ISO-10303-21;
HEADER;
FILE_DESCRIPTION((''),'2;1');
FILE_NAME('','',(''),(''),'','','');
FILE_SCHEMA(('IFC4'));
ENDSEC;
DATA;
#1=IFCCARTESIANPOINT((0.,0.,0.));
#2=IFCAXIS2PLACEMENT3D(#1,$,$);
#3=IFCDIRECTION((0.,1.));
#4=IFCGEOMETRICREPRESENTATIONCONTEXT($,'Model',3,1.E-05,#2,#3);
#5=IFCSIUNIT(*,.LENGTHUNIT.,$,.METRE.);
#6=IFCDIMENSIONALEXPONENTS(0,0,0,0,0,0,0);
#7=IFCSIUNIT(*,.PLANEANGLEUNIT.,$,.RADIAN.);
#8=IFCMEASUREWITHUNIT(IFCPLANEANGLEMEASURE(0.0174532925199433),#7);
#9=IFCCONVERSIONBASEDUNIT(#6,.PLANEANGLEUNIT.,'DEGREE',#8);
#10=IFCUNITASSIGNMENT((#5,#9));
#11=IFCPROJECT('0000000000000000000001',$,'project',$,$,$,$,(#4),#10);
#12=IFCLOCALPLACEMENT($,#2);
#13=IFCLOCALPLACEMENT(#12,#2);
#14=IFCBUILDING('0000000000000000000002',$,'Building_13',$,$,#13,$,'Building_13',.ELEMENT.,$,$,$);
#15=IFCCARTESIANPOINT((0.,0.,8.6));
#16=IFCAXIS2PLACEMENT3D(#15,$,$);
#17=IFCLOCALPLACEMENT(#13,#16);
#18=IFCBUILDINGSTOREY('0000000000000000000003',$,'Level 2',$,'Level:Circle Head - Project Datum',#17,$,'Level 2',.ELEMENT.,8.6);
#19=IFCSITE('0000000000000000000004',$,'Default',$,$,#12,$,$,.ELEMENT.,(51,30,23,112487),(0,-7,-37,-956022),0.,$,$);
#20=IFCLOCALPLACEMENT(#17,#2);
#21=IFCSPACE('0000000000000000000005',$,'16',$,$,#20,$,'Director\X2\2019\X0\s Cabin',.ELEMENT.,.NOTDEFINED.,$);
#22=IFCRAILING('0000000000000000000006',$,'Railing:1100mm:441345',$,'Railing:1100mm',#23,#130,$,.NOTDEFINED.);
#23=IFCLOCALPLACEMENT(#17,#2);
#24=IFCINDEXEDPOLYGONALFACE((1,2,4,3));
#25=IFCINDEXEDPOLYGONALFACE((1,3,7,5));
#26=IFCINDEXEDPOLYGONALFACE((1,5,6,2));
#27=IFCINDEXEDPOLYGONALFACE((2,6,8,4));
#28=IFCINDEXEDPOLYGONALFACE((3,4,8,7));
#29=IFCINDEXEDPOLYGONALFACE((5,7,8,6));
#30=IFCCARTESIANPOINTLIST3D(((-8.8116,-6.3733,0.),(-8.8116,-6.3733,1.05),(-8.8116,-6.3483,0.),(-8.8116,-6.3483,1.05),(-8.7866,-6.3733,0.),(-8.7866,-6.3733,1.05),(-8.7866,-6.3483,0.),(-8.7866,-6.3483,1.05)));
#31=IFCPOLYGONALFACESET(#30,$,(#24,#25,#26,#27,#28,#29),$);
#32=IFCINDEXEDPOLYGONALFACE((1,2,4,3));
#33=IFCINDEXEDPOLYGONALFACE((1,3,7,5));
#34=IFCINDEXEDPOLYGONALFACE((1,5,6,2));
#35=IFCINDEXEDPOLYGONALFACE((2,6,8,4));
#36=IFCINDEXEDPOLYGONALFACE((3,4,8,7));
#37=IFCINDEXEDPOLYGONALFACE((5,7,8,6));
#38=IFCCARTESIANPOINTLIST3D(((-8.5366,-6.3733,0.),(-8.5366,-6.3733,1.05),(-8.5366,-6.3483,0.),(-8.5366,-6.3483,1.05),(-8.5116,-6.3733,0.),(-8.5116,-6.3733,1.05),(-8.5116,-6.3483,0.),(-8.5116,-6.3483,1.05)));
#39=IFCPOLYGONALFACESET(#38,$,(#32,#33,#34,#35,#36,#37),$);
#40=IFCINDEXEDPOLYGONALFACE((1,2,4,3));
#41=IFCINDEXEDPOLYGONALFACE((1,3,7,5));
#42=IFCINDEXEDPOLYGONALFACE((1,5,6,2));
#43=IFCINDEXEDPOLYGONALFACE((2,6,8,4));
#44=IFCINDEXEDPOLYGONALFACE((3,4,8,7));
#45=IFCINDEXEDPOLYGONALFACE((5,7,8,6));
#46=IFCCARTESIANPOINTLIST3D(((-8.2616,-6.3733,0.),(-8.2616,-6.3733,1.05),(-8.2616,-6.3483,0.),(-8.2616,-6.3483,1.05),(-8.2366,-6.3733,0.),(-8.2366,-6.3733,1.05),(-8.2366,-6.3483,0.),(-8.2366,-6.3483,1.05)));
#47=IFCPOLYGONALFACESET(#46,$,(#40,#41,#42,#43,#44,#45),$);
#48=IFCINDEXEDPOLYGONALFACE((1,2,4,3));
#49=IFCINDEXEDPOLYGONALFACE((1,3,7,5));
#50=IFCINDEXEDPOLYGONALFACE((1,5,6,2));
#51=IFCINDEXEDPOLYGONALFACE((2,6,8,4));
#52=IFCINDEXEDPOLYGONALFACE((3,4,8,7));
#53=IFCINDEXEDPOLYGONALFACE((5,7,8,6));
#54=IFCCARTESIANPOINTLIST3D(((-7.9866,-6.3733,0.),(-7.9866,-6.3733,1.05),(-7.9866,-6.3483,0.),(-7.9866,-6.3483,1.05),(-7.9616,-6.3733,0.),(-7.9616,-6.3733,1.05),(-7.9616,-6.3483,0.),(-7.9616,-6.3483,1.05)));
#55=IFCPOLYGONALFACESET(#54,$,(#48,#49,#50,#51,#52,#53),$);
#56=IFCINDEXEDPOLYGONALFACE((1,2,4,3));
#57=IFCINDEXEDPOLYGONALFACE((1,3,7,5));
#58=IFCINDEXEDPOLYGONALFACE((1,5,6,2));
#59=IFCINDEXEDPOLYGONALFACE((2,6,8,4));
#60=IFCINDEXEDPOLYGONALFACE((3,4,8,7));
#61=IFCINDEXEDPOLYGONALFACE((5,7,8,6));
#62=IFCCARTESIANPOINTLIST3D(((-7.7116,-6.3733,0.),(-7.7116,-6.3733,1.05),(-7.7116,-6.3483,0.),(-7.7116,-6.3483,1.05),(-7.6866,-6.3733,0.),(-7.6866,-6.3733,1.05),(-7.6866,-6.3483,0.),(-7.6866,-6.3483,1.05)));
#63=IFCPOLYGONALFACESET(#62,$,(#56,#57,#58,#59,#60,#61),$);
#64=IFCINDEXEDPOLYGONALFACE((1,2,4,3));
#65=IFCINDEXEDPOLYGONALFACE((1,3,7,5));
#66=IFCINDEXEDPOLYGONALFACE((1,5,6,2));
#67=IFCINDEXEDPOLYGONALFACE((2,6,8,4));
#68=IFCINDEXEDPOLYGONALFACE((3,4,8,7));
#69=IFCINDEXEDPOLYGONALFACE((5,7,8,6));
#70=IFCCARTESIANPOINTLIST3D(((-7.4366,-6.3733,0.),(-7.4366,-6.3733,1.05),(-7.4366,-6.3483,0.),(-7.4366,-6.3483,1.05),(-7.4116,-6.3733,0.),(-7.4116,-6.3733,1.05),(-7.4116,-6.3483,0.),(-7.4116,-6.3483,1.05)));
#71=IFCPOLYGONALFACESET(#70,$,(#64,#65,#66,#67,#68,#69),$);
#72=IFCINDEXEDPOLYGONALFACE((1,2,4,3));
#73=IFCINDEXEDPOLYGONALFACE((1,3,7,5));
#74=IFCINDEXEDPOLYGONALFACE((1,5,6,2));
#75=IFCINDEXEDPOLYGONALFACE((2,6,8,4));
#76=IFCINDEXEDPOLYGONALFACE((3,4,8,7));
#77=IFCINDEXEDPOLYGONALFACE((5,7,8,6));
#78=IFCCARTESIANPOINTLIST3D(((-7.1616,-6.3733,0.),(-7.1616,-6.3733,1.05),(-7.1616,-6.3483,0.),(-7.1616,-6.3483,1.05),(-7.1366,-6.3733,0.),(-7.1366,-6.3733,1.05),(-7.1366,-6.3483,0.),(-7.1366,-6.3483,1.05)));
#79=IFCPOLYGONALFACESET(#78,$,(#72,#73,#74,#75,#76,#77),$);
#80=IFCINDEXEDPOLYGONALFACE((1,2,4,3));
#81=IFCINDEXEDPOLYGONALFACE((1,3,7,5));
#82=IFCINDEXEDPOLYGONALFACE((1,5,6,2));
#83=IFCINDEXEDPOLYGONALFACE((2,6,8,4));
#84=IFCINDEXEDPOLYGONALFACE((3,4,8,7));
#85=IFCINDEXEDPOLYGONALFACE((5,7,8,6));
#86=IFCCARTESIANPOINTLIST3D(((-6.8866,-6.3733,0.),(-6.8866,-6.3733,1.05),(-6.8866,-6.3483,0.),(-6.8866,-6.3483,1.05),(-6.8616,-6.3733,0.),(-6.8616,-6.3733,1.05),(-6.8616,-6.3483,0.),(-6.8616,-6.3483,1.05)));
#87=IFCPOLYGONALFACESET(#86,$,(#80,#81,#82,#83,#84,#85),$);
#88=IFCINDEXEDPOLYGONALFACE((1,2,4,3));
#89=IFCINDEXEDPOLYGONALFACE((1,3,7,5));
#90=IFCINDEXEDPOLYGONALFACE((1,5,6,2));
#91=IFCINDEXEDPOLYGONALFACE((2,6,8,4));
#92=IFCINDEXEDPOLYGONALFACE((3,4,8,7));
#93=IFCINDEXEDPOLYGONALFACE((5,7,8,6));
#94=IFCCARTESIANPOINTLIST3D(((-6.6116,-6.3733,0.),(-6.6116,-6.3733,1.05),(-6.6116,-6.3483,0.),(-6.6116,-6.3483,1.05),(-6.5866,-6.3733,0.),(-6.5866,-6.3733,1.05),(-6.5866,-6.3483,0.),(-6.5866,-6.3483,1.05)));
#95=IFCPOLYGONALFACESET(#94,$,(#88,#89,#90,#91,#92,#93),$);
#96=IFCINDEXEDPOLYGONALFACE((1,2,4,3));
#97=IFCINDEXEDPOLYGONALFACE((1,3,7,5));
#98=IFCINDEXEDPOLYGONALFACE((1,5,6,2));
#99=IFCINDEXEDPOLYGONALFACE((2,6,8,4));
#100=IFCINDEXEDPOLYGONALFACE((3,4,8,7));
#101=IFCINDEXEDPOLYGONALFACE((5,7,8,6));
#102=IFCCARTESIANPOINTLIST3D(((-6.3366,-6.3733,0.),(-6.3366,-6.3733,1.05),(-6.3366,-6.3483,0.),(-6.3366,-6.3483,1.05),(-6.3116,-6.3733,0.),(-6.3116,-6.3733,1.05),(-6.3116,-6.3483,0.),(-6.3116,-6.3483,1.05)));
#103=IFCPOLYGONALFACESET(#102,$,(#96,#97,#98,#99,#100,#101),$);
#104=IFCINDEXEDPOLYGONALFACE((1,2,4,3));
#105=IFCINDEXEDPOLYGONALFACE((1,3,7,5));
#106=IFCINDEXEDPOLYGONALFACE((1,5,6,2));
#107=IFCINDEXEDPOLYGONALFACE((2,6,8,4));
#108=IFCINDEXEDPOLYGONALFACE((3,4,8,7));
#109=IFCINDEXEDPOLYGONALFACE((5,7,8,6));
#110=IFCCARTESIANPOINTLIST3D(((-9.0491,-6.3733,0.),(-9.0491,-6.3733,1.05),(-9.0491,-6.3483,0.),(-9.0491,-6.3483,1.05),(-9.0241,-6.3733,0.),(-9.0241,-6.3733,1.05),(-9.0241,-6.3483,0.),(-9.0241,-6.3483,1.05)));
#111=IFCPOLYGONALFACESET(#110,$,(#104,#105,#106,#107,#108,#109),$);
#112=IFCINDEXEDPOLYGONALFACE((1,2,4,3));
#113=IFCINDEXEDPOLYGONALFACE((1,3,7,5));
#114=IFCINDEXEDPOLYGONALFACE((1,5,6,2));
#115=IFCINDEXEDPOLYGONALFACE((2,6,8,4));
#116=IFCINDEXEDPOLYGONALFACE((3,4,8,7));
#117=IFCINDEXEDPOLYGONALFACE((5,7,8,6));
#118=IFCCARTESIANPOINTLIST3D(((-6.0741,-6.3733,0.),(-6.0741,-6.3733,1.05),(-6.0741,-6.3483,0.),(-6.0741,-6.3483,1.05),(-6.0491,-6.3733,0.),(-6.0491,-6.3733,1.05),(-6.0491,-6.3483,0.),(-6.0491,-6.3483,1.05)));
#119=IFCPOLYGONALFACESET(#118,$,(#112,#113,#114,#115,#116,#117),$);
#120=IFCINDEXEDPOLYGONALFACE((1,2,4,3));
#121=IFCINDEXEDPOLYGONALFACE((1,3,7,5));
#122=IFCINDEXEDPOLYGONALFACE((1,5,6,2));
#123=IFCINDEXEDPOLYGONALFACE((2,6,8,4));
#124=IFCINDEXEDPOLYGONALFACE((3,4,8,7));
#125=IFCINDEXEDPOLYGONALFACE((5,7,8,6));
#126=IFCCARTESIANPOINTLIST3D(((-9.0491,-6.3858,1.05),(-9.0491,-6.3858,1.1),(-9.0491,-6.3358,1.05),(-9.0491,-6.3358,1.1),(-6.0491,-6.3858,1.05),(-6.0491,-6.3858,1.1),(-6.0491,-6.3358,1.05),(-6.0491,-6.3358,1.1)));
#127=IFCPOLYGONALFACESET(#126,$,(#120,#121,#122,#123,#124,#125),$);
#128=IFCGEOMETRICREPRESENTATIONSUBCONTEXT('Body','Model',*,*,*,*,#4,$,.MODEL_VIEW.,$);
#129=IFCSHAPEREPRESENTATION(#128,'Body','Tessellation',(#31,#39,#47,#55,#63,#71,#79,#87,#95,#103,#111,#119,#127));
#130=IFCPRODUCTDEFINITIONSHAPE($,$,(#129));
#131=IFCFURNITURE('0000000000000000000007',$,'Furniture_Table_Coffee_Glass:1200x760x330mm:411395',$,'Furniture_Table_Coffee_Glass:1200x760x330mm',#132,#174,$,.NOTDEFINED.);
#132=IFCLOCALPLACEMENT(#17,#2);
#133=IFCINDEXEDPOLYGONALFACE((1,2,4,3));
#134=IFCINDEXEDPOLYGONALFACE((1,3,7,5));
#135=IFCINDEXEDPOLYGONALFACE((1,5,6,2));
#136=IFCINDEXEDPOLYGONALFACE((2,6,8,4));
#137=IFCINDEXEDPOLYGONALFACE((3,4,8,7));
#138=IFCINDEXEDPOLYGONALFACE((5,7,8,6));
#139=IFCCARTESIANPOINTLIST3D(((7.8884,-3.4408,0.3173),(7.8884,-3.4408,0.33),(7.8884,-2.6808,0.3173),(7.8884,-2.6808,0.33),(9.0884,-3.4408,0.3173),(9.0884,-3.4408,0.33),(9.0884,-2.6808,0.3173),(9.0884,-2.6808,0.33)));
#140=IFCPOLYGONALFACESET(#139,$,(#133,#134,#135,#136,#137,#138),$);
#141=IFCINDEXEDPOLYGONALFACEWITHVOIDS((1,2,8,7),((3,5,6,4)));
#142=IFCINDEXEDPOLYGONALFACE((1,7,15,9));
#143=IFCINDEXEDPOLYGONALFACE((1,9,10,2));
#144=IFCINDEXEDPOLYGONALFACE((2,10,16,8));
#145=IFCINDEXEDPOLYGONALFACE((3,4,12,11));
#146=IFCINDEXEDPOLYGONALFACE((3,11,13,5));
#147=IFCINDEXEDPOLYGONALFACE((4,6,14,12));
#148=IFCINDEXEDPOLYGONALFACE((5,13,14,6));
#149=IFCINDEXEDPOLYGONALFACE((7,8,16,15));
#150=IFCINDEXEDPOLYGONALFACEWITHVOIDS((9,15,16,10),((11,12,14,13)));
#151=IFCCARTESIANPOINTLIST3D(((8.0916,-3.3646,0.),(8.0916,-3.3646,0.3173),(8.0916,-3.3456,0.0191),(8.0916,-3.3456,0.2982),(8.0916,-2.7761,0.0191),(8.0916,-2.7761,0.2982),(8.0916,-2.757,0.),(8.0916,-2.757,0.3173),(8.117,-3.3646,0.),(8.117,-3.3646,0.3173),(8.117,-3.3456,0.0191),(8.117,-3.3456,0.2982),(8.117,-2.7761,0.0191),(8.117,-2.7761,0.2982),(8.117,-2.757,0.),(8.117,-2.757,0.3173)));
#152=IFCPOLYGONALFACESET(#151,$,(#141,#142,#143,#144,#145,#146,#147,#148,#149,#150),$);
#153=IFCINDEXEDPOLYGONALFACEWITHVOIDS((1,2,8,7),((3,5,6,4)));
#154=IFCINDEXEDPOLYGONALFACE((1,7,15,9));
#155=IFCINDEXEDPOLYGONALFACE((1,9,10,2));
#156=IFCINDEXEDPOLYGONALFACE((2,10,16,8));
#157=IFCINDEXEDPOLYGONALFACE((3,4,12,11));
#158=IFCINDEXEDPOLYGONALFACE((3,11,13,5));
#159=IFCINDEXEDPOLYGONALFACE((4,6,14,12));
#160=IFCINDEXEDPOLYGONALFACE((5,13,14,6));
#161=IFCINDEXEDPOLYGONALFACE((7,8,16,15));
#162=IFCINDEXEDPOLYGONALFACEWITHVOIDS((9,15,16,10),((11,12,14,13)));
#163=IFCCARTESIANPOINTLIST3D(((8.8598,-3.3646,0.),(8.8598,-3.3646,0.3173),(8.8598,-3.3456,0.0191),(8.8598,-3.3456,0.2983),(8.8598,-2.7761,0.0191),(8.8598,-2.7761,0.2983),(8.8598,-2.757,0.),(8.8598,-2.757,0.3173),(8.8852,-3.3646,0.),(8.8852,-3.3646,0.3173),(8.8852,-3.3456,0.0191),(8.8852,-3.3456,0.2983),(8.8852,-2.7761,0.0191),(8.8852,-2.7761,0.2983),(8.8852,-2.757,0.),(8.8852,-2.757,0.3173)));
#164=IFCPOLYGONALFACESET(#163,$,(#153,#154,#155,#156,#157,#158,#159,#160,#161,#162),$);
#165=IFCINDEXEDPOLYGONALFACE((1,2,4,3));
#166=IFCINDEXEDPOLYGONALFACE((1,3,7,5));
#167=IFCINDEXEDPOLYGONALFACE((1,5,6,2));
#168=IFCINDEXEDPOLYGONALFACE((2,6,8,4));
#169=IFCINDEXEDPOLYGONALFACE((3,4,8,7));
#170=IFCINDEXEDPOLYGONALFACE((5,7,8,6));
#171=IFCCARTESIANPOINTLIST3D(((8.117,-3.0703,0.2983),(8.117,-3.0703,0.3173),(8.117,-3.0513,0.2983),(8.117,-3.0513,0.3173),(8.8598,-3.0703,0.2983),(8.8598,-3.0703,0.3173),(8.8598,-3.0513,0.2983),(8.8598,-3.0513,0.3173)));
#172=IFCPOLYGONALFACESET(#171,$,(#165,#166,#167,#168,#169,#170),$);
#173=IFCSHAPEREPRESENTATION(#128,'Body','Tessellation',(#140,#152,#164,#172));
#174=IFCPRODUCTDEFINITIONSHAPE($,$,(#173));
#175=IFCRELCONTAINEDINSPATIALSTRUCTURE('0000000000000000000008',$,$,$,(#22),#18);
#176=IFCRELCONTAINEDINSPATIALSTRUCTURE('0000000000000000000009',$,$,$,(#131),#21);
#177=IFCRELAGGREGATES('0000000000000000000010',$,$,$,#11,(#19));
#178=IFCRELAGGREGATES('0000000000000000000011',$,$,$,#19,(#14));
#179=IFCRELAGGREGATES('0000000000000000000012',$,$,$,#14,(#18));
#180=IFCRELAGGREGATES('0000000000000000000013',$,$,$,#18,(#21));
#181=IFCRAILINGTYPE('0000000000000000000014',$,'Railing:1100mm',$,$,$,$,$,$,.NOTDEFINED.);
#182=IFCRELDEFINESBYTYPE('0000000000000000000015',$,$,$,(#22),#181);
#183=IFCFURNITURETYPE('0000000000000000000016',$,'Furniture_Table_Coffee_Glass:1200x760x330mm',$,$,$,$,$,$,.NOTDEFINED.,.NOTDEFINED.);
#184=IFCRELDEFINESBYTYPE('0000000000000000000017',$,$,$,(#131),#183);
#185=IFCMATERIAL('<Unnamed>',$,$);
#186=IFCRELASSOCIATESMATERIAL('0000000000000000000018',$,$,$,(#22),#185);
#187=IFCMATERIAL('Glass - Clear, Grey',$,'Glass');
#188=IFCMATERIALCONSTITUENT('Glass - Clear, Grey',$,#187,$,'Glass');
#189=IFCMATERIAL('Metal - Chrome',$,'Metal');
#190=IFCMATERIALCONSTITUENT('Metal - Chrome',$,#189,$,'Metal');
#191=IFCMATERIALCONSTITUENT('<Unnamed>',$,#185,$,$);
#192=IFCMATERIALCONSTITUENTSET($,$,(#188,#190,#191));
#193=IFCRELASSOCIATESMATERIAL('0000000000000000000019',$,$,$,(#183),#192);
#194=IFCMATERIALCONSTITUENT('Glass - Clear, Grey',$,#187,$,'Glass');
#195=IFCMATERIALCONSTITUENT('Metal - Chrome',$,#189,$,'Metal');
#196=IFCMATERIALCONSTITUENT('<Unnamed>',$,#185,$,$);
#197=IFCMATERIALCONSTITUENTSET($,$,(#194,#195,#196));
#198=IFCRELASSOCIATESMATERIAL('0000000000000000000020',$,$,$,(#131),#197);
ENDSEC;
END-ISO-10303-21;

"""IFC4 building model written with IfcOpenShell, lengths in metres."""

from ifc_helpers import new_model, entity, si_unit, converted_unit, direction, frame, origin, place, context, subcontext, project, spatial, indexed_curve, outline, extrude, source, transform, mapped, material, constituent, constituent_set, type_object, type_shapes, element, save


model = new_model("IFC4")

# Units and contexts
model_context = context("Model", 3, precision=1e-05, world=origin(), true_north=direction((0.0, 1.0)))
body_context = subcontext(model_context, "Body", "Model", "MODEL_VIEW")
ifc_project = project(units=[si_unit("LENGTHUNIT", "METRE"), converted_unit("PLANEANGLEUNIT", "DEGREE", entity("IfcPlaneAngleMeasure", 0.0174532925199433), si_unit("PLANEANGLEUNIT", "RADIAN"), dimensions=[0, 0, 0, 0, 0, 0, 0])], contexts=[model_context])

# Site, building, storey
site_placement = place(None, origin())
site = spatial("IfcSite", under=ifc_project, at=site_placement, Name="Default", CompositionType="ELEMENT", RefLatitude=(51, 30, 23, 112487), RefLongitude=(0, -7, -37, -956022), RefElevation=0.0)
building_placement = place(site_placement, origin())
building = spatial("IfcBuilding", under=site, at=building_placement, Name="Building_13", LongName="Building_13", CompositionType="ELEMENT")
storey_placement = place(building_placement, frame((0.0, 0.0, 8.6)))
storey = spatial("IfcBuildingStorey", under=building, at=storey_placement, Name="Level 2", ObjectType="Level:Circle Head - Project Datum", LongName="Level 2", CompositionType="ELEMENT", Elevation=8.6)

# Shared definitions
ifc_material_1 = material(Name="<Unnamed>")

# Shared definitions
railing_type_1 = type_object("IfcRailingType", Name="Railing:1100mm", PredefinedType="NOTDEFINED")

# Railing
railing_1_placement = place(storey_placement, origin())
element("IfcRailing", 1, at=railing_1_placement, inside=storey, type_object=railing_type_1, material=ifc_material_1, Name="Railing:1100mm:441345", ObjectType="Railing:1100mm", PredefinedType="NOTDEFINED", context=body_context, shape_type="SweptSolid", body=[
    extrude(outline(indexed_curve([(-0.0125, -0.0125), (0.0125, -0.0125), (0.0125, 0.0125), (-0.0125, 0.0125), (-0.0125, -0.0125)], self_intersect=False)), frame((-8.7991, -6.3608, 0.0), z_axis=(0.0, 0.0, 1.0), x_axis=(-1.0, 0.0, 0.0)), (0.0, 0.0, 1.0), 1.05),
    extrude(outline(indexed_curve([(-0.0125, -0.0125), (0.0125, -0.0125), (0.0125, 0.0125), (-0.0125, 0.0125), (-0.0125, -0.0125)], self_intersect=False)), frame((-8.5241, -6.3608, 0.0), z_axis=(0.0, 0.0, 1.0), x_axis=(-1.0, 0.0, 0.0)), (0.0, 0.0, 1.0), 1.05),
    extrude(outline(indexed_curve([(-0.0125, -0.0125), (0.0125, -0.0125), (0.0125, 0.0125), (-0.0125, 0.0125), (-0.0125, -0.0125)], self_intersect=False)), frame((-8.2491, -6.3608, 0.0), z_axis=(0.0, 0.0, 1.0), x_axis=(-1.0, 0.0, 0.0)), (0.0, 0.0, 1.0), 1.05),
    extrude(outline(indexed_curve([(-0.0125, -0.0125), (0.0125, -0.0125), (0.0125, 0.0125), (-0.0125, 0.0125), (-0.0125, -0.0125)], self_intersect=False)), frame((-7.9741, -6.3608, 0.0), z_axis=(0.0, 0.0, 1.0), x_axis=(-1.0, 0.0, 0.0)), (0.0, 0.0, 1.0), 1.05),
    extrude(outline(indexed_curve([(-0.0125, -0.0125), (0.0125, -0.0125), (0.0125, 0.0125), (-0.0125, 0.0125), (-0.0125, -0.0125)], self_intersect=False)), frame((-7.6991, -6.3608, 0.0), z_axis=(0.0, 0.0, 1.0), x_axis=(-1.0, 0.0, 0.0)), (0.0, 0.0, 1.0), 1.05),
    extrude(outline(indexed_curve([(-0.0125, -0.0125), (0.0125, -0.0125), (0.0125, 0.0125), (-0.0125, 0.0125), (-0.0125, -0.0125)], self_intersect=False)), frame((-7.4241, -6.3608, 0.0), z_axis=(0.0, 0.0, 1.0), x_axis=(-1.0, 0.0, 0.0)), (0.0, 0.0, 1.0), 1.05),
    extrude(outline(indexed_curve([(-0.0125, -0.0125), (0.0125, -0.0125), (0.0125, 0.0125), (-0.0125, 0.0125), (-0.0125, -0.0125)], self_intersect=False)), frame((-7.1491, -6.3608, 0.0), z_axis=(0.0, 0.0, 1.0), x_axis=(-1.0, 0.0, 0.0)), (0.0, 0.0, 1.0), 1.05),
    extrude(outline(indexed_curve([(-0.0125, -0.0125), (0.0125, -0.0125), (0.0125, 0.0125), (-0.0125, 0.0125), (-0.0125, -0.0125)], self_intersect=False)), frame((-6.8741, -6.3608, 0.0), z_axis=(0.0, 0.0, 1.0), x_axis=(-1.0, 0.0, 0.0)), (0.0, 0.0, 1.0), 1.05),
    extrude(outline(indexed_curve([(-0.0125, -0.0125), (0.0125, -0.0125), (0.0125, 0.0125), (-0.0125, 0.0125), (-0.0125, -0.0125)], self_intersect=False)), frame((-6.5991, -6.3608, 0.0), z_axis=(0.0, 0.0, 1.0), x_axis=(-1.0, 0.0, 0.0)), (0.0, 0.0, 1.0), 1.05),
    extrude(outline(indexed_curve([(-0.0125, -0.0125), (0.0125, -0.0125), (0.0125, 0.0125), (-0.0125, 0.0125), (-0.0125, -0.0125)], self_intersect=False)), frame((-6.3241, -6.3608, 0.0), z_axis=(0.0, 0.0, 1.0), x_axis=(-1.0, 0.0, 0.0)), (0.0, 0.0, 1.0), 1.05),
    extrude(outline(indexed_curve([(-0.0125, -0.0125), (0.0125, -0.0125), (0.0125, 0.0125), (-0.0125, 0.0125), (-0.0125, -0.0125)], self_intersect=False)), frame((-9.0366, -6.3608, 0.0), z_axis=(0.0, 0.0, 1.0), x_axis=(-1.0, 0.0, 0.0)), (0.0, 0.0, 1.0), 1.05),
    extrude(outline(indexed_curve([(-0.0125, -0.0125), (0.0125, -0.0125), (0.0125, 0.0125), (-0.0125, 0.0125), (-0.0125, -0.0125)], self_intersect=False)), frame((-6.0616, -6.3608, 0.0), z_axis=(0.0, 0.0, 1.0), x_axis=(-1.0, 0.0, 0.0)), (0.0, 0.0, 1.0), 1.05),
    extrude(outline(indexed_curve([(-1.5, -0.025), (1.5, -0.025), (1.5, 0.025), (-1.5, 0.025), (-1.5, -0.025)], self_intersect=False)), frame((-7.5491, -6.3608, 1.05), z_axis=(0.0, 0.0, 1.0), x_axis=(-1.0, 0.0, 0.0)), (0.0, 0.0, 1.0), 0.05),
])

# Shared definitions
space_placement = place(storey_placement, origin())
space = spatial("IfcSpace", under=storey, at=space_placement, Name="16", LongName="Director’s Cabin", CompositionType="ELEMENT", PredefinedType="NOTDEFINED")

# Furniture
ifc_material_2 = material(Name="Glass - Clear, Grey", Category="Glass")
ifc_constituent_1 = constituent(ifc_material_2, Name="Glass - Clear, Grey", Category="Glass")
ifc_material_3 = material(Name="Metal - Chrome", Category="Metal")
ifc_constituent_2 = constituent(ifc_material_3, Name="Metal - Chrome", Category="Metal")
ifc_constituent_3 = constituent(ifc_material_1, Name="<Unnamed>")
ifc_constituent_set_1 = constituent_set(constituents=[ifc_constituent_1, ifc_constituent_2, ifc_constituent_3])
ifc_constituent_4 = constituent(ifc_material_2, Name="Glass - Clear, Grey", Category="Glass")
ifc_constituent_5 = constituent(ifc_material_3, Name="Metal - Chrome", Category="Metal")
ifc_constituent_6 = constituent(ifc_material_1, Name="<Unnamed>")
ifc_constituent_set_2 = constituent_set(constituents=[ifc_constituent_4, ifc_constituent_5, ifc_constituent_6])
furniture_type = type_object("IfcFurnitureType", Name="Furniture_Table_Coffee_Glass:1200x760x330mm", AssemblyPlace="NOTDEFINED", PredefinedType="NOTDEFINED", material=ifc_constituent_set_2)
shared_shape_1 = source(origin(), body_context, "Body", "SweptSolid", [
    extrude(outline(indexed_curve([(-0.6, -0.38), (0.6, -0.38), (0.6, 0.38), (-0.6, 0.38), (-0.6, -0.38)], self_intersect=False)), frame((0.6037, 0.3686, 0.3173), z_axis=(0.0, 0.0, 1.0), x_axis=(-1.0, 0.0, 0.0)), (0.0, 0.0, 1.0), 0.0127),
    extrude(outline(indexed_curve([(-0.1587, -0.3038), (0.1587, -0.3038), (0.1587, 0.3038), (-0.1587, 0.3038), (-0.1587, -0.3038)], self_intersect=False), holes=[indexed_curve([(-0.1396, -0.2848), (-0.1396, 0.2848), (0.1396, 0.2848), (0.1396, -0.2848), (-0.1396, -0.2848)], self_intersect=False)]), frame((0.2069, 0.3686, 0.1587), z_axis=(1.0, 0.0, 0.0), x_axis=(0.0, 0.0, -1.0)), (0.0, 0.0, 1.0), 0.0254),
    extrude(outline(indexed_curve([(-0.1586, -0.3038), (0.1586, -0.3038), (0.1586, 0.3038), (-0.1586, 0.3038), (-0.1586, -0.3038)], self_intersect=False), holes=[indexed_curve([(-0.1396, -0.2848), (-0.1396, 0.2848), (0.1396, 0.2848), (0.1396, -0.2848), (-0.1396, -0.2848)], self_intersect=False)]), frame((0.9751, 0.3686, 0.1586), z_axis=(1.0, 0.0, 0.0), x_axis=(0.0, 0.0, -1.0)), (0.0, 0.0, 1.0), 0.0254),
    extrude(outline(indexed_curve([(-0.3714, -0.0095), (0.3714, -0.0095), (0.3714, 0.0095), (-0.3714, 0.0095), (-0.3714, -0.0095)], self_intersect=False)), frame((0.6037, 0.3686, 0.2983), z_axis=(0.0, 0.0, 1.0), x_axis=(-1.0, 0.0, 0.0)), (0.0, 0.0, 1.0), 0.0191),
])
type_shapes(furniture_type, [shared_shape_1])
furniture_placement = place(space_placement, frame((7.8847, -3.4294, 0.0)))
element("IfcFurniture", 2, at=furniture_placement, inside=space, type_object=furniture_type, material=ifc_constituent_set_1, Name="Furniture_Table_Coffee_Glass:1200x760x330mm:411395", ObjectType="Furniture_Table_Coffee_Glass:1200x760x330mm", PredefinedType="NOTDEFINED", context=body_context, shape_type="MappedRepresentation", body=[
    mapped(shared_shape_1, transform((0.0, 0.0, 0.0), scale=1.0)),
])

save(model, "model.ifc")
